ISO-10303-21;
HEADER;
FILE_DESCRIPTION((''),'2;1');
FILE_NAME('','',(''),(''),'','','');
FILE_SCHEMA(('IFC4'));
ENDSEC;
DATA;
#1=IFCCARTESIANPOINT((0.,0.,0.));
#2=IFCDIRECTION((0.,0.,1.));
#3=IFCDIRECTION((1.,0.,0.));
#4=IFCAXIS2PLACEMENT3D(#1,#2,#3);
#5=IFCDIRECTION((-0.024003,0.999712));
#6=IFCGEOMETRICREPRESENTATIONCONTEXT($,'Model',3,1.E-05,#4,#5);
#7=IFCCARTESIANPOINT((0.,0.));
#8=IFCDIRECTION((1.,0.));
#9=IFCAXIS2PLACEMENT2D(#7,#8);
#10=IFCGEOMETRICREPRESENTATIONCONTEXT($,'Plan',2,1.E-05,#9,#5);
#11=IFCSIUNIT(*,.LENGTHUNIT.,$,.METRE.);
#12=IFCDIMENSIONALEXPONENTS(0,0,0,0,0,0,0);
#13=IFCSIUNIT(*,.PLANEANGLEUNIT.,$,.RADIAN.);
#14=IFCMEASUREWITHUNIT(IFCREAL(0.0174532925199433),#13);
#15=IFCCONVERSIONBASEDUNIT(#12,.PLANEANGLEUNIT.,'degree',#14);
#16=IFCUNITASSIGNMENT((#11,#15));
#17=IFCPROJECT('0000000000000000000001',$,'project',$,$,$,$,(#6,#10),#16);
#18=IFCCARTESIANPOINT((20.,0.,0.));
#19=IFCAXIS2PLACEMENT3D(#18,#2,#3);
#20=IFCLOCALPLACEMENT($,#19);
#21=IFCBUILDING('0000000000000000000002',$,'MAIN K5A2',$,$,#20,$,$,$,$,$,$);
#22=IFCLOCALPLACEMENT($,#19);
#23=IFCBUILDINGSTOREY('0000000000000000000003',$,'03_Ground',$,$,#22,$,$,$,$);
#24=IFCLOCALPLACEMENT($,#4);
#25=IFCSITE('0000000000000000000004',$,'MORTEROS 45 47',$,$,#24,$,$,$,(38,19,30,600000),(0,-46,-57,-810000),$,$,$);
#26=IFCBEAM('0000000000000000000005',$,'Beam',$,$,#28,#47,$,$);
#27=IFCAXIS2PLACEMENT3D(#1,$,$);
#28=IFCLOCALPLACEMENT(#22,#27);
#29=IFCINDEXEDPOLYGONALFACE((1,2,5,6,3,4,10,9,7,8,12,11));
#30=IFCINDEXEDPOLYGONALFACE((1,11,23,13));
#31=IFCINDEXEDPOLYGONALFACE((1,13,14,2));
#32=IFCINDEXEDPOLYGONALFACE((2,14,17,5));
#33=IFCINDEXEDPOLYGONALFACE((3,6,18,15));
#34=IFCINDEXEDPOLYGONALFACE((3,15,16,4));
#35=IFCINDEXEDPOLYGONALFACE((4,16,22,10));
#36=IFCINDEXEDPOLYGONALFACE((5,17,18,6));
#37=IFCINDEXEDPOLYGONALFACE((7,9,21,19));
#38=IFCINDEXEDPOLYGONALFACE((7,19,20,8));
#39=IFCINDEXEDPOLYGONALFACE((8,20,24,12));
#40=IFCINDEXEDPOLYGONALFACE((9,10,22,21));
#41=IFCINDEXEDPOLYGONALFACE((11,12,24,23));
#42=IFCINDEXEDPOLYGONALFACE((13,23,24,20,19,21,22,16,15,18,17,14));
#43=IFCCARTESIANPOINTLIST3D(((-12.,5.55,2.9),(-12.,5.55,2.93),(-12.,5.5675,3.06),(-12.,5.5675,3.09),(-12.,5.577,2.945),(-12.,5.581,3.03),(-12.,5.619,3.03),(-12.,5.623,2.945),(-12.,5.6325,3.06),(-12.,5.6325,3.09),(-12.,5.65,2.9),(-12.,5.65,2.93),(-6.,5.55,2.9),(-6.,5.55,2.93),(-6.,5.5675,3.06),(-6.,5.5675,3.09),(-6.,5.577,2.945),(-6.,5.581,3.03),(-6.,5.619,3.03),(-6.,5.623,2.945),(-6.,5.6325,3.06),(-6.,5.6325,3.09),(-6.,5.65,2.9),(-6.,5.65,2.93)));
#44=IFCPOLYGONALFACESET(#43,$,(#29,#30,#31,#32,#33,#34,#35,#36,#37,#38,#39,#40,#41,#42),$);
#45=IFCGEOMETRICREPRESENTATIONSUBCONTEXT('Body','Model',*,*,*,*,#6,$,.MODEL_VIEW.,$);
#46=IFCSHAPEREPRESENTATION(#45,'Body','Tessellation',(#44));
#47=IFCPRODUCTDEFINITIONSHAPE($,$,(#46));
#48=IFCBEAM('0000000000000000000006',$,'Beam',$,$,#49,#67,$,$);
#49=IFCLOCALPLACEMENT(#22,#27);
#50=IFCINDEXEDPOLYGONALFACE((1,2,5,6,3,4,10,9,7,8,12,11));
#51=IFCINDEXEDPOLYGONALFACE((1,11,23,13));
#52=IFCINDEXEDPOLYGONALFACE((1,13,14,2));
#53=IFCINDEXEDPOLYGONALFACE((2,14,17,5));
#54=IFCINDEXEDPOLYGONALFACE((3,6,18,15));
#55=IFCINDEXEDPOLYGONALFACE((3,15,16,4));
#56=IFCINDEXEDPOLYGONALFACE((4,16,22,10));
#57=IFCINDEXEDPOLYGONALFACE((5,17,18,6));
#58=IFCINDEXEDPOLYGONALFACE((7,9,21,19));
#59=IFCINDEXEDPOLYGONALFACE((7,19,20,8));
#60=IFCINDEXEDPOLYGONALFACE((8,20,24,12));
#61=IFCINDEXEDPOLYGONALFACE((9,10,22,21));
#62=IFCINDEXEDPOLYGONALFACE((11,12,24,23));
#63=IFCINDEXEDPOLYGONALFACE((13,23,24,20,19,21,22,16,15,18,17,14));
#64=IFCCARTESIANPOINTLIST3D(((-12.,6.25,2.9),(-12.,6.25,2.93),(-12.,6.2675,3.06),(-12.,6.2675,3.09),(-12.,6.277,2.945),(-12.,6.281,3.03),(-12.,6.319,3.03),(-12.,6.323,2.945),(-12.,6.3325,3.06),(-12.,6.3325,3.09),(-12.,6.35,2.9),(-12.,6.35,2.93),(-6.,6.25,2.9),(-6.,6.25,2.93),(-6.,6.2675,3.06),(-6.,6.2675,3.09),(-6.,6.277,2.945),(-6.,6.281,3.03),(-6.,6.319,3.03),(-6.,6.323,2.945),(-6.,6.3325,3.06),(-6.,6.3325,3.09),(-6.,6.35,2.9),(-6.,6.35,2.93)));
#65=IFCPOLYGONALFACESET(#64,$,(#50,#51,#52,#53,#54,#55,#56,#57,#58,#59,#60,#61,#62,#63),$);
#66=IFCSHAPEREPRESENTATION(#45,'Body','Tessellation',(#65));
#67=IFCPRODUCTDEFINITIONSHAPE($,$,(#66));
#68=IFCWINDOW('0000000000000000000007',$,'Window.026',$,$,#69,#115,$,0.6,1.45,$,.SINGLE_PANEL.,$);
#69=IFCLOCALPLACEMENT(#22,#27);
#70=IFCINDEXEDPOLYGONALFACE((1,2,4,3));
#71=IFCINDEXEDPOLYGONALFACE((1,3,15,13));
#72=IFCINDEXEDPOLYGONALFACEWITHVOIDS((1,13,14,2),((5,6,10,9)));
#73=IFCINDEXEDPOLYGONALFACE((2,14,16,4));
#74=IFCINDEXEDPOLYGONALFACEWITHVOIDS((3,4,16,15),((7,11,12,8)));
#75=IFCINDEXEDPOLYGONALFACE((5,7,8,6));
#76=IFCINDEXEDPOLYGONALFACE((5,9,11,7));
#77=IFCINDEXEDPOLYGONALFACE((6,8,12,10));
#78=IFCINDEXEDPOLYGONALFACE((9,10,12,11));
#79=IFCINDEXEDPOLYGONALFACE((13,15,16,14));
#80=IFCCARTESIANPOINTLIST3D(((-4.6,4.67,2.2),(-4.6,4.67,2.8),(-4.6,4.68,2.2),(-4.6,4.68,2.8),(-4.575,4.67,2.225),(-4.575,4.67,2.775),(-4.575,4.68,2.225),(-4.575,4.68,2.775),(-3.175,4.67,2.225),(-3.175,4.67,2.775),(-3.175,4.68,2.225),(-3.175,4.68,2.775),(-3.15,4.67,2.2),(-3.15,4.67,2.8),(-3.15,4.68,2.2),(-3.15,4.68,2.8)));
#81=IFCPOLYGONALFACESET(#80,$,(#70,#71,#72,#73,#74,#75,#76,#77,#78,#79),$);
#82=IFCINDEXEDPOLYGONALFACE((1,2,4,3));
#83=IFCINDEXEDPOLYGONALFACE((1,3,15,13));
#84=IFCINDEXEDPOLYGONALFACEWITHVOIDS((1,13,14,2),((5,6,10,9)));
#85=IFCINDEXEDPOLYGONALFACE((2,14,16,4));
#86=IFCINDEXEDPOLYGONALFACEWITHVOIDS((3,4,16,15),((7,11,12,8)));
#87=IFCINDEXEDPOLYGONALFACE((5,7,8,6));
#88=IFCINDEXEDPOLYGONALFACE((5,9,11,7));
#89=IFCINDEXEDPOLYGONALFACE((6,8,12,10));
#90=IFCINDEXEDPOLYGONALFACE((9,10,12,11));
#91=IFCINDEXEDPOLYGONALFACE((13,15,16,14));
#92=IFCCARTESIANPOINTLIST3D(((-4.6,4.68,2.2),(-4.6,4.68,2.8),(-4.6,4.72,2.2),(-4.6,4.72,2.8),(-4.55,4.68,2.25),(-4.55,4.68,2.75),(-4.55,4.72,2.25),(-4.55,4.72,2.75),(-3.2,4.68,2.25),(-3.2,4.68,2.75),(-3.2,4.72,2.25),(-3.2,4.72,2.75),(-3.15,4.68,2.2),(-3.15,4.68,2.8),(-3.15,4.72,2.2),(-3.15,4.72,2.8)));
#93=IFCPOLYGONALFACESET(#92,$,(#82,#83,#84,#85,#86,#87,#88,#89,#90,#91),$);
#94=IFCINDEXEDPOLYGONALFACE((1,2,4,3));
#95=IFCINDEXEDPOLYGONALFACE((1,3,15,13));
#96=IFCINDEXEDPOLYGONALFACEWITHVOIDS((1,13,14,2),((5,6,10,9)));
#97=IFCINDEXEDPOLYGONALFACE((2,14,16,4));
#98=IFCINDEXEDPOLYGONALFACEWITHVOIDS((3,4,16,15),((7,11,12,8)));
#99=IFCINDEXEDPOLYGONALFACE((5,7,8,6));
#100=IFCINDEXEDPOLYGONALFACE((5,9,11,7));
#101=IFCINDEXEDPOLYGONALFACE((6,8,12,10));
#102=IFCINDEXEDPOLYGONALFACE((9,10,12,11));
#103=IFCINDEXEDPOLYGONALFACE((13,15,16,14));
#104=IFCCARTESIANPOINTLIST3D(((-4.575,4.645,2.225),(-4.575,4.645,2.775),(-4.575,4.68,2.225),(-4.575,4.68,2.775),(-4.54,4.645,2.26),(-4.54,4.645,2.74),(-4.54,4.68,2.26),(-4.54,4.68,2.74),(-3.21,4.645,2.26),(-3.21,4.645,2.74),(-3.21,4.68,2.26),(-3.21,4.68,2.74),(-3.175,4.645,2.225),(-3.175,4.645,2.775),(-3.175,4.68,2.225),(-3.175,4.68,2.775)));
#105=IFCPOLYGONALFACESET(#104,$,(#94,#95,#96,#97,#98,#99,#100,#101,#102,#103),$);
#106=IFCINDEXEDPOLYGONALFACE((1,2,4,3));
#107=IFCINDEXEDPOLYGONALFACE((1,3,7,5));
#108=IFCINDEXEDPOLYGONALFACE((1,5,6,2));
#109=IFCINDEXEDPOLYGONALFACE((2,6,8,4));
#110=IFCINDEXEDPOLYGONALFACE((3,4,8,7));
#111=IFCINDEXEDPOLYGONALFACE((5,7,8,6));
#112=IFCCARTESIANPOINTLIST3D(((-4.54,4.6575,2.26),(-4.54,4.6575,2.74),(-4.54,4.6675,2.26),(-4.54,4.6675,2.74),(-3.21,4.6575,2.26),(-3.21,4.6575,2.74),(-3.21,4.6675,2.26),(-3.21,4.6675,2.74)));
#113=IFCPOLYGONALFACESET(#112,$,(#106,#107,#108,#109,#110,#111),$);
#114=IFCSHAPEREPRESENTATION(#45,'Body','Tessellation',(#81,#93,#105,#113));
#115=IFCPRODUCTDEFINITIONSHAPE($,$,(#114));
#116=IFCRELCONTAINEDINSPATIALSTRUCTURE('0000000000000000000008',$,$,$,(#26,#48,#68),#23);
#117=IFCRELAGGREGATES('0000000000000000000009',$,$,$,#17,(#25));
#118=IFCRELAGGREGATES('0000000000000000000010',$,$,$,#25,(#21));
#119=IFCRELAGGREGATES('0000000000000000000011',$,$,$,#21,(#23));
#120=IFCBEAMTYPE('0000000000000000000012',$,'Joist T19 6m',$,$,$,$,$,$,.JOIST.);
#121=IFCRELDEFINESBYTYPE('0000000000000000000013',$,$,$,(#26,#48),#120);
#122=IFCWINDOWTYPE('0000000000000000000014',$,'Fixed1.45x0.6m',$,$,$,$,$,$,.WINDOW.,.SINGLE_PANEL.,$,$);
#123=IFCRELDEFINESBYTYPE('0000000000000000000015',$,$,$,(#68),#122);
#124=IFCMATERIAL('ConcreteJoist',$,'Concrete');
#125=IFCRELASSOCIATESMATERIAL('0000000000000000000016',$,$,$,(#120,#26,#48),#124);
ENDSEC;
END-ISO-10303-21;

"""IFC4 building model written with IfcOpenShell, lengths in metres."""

from ifc_helpers import new_model, entity, si_unit, converted_unit, direction, frame, origin_with_axes, origin_2d_with_axis, place, context, subcontext, project, spatial, line, indexed_curve, outline, extrude, shape, source, transform, mapped, material, material_profile, profile_set, profile_usage, type_object, element, save


model = new_model("IFC4")

# Units and contexts
model_context = context("Model", 3, precision=1e-05, world=origin_with_axes(), true_north=direction((-0.024003, 0.999712)))
plan_context = context("Plan", 2, precision=1e-05, world=origin_2d_with_axis(), true_north=direction((-0.024003, 0.999712)))
body_context_1 = subcontext(model_context, "Body", "Model", "MODEL_VIEW")
body_context_2 = subcontext(plan_context, "Body", "Plan", "PLAN_VIEW")
ifc_project = project(units=[si_unit("LENGTHUNIT", "METRE"), converted_unit("PLANEANGLEUNIT", "degree", entity("IfcReal", 0.0174532925199433), si_unit("PLANEANGLEUNIT", "RADIAN"), dimensions=[0, 0, 0, 0, 0, 0, 0])], contexts=[model_context, plan_context])

# Site, building, storey
site_placement = place(None, origin_with_axes())
site = spatial("IfcSite", under=ifc_project, at=site_placement, Name="MORTEROS 45 47", RefLatitude=(38, 19, 30, 600000), RefLongitude=(0, -46, -57, -810000))
building_placement = place(None, frame((20.0, 0.0, 0.0), z_axis=(0.0, 0.0, 1.0), x_axis=(1.0, 0.0, 0.0)))
building = spatial("IfcBuilding", under=site, at=building_placement, Name="MAIN K5A2")
storey_placement = place(None, frame((20.0, 0.0, 0.0), z_axis=(0.0, 0.0, 1.0), x_axis=(1.0, 0.0, 0.0)))
storey = spatial("IfcBuildingStorey", under=building, at=storey_placement, Name="03_Ground")

# Beams
ifc_material = material(Name="ConcreteJoist", Category="Concrete")
ifc_material_profile = material_profile(ifc_material, outline(indexed_curve([(0.019, 0.13), (0.023, 0.045), (0.05, 0.03), (0.05, 0.0), (-0.05, 0.0), (-0.05, 0.03), (-0.023, 0.045), (-0.019, 0.13), (-0.0325, 0.16), (-0.0325, 0.19), (0.0325, 0.19), (0.0325, 0.16), (0.019, 0.13)])))
ifc_profile_set = profile_set([ifc_material_profile], Name="JoistmaterialProfile")
beam_type = type_object("IfcBeamType", Name="Joist T19 6m", PredefinedType="JOIST", material=ifc_profile_set)
ifc_profile_usage_1 = profile_usage(ifc_profile_set)
beam_1_placement = place(None, frame((8.0, 5.6, 2.9), z_axis=(1.0, 0.0, 0.0), x_axis=(0.0, 1.0, 0.0)))
element("IfcBeam", 1, at=beam_1_placement, inside=storey, type_object=beam_type, material=ifc_profile_usage_1, Name="Beam", context=body_context_1, shape_type="SweptSolid", body=[
    extrude(outline(indexed_curve([(0.019, 0.13), (0.023, 0.045), (0.05, 0.03), (0.05, 0.0), (-0.05, 0.0), (-0.05, 0.03), (-0.023, 0.045), (-0.019, 0.13), (-0.0325, 0.16), (-0.0325, 0.19), (0.0325, 0.19), (0.0325, 0.16), (0.019, 0.13)])), origin_with_axes(), (0.0, 0.0, 1.0), 6.0),
])
ifc_profile_usage_2 = profile_usage(ifc_profile_set)
beam_2_placement = place(None, frame((8.0, 6.3, 2.9), z_axis=(1.0, 0.0, 0.0), x_axis=(0.0, 1.0, 0.0)))
element("IfcBeam", 2, at=beam_2_placement, inside=storey, type_object=beam_type, material=ifc_profile_usage_2, Name="Beam", context=body_context_1, shape_type="SweptSolid", body=[
    extrude(outline(indexed_curve([(0.019, 0.13), (0.023, 0.045), (0.05, 0.03), (0.05, 0.0), (-0.05, 0.0), (-0.05, 0.03), (-0.023, 0.045), (-0.019, 0.13), (-0.0325, 0.16), (-0.0325, 0.19), (0.0325, 0.19), (0.0325, 0.16), (0.019, 0.13)])), origin_with_axes(), (0.0, 0.0, 1.0), 6.0),
])

# Window
window_type_1 = type_object("IfcWindowType", Name="Fixed1.45x0.6m", PartitioningType="SINGLE_PANEL", PredefinedType="WINDOW")
shared_shape_1 = source(origin_with_axes(), body_context_1, "Body", "SolidModel", [
    extrude(outline(indexed_curve([(0.0, 0.0), (1.45, 0.0), (1.45, 0.6), (0.0, 0.6)], segments=[line(1, 2, 3, 4, 1)]), holes=[indexed_curve([(0.025, 0.025), (1.425, 0.025), (1.425, 0.575), (0.025, 0.575)], segments=[line(1, 2, 3, 4, 1)])]), frame((0.0, 0.09, 0.0), z_axis=(0.0, -1.0, 0.0), x_axis=(1.0, 0.0, 0.0)), (0.0, 0.0, -1.0), 0.01),
    extrude(outline(indexed_curve([(0.0, 0.0), (1.45, 0.0), (1.45, 0.6), (0.0, 0.6)], segments=[line(1, 2, 3, 4, 1)]), holes=[indexed_curve([(0.05, 0.05), (1.4, 0.05), (1.4, 0.55), (0.05, 0.55)], segments=[line(1, 2, 3, 4, 1)])]), frame((0.0, 0.05, 0.0), z_axis=(0.0, -1.0, 0.0), x_axis=(1.0, 0.0, 0.0)), (0.0, 0.0, -1.0), 0.04),
    extrude(outline(indexed_curve([(0.0, 0.0), (1.4, 0.0), (1.4, 0.55), (0.0, 0.55)], segments=[line(1, 2, 3, 4, 1)]), holes=[indexed_curve([(0.035, 0.035), (1.365, 0.035), (1.365, 0.515), (0.035, 0.515)], segments=[line(1, 2, 3, 4, 1)])]), frame((0.025, 0.09, 0.025), z_axis=(0.0, -1.0, 0.0), x_axis=(1.0, 0.0, 0.0)), (0.0, 0.0, -1.0), 0.035),
    extrude(outline(indexed_curve([(0.035, 0.035), (1.365, 0.035), (1.365, 0.515), (0.035, 0.515)], segments=[line(1, 2, 3, 4, 1)])), frame((0.025, 0.1025, 0.025), z_axis=(0.0, -1.0, 0.0), x_axis=(1.0, 0.0, 0.0)), (0.0, 0.0, -1.0), 0.01),
])
shared_shape_2 = source(origin_with_axes(), body_context_2, "Body", "Curve2D", [
    entity("IfcIndexedPolyCurve", entity("IfcCartesianPointList2D", [[0.05, 0.05], [1.4, 0.05]])),
    entity("IfcIndexedPolyCurve", entity("IfcCartesianPointList2D", [[0.0, 0.1], [0.025, 0.1], [0.025, 0.09], [0.05, 0.09], [0.05, 0.05], [0.0, 0.05]]), [entity("IfcLineIndex", [1, 2, 3, 4, 5, 6, 1])]),
    entity("IfcIndexedPolyCurve", entity("IfcCartesianPointList2D", [[1.45, 0.1], [1.425, 0.1], [1.425, 0.09], [1.4, 0.09], [1.4, 0.05], [1.45, 0.05]]), [entity("IfcLineIndex", [1, 2, 3, 4, 5, 6, 1])]),
    entity("IfcIndexedPolyCurve", entity("IfcCartesianPointList2D", [[0.025, 0.09], [0.06, 0.09], [0.06, 0.125], [0.025, 0.125]]), [entity("IfcLineIndex", [1, 2, 3, 4, 1])]),
    entity("IfcIndexedPolyCurve", entity("IfcCartesianPointList2D", [[1.425, 0.09], [1.39, 0.09], [1.39, 0.125], [1.425, 0.125]]), [entity("IfcLineIndex", [1, 2, 3, 4, 1])]),
    entity("IfcIndexedPolyCurve", entity("IfcCartesianPointList2D", [[0.06, 0.09], [1.39, 0.09]])),
    entity("IfcIndexedPolyCurve", entity("IfcCartesianPointList2D", [[0.06, 0.125], [1.39, 0.125]])),
    entity("IfcIndexedPolyCurve", entity("IfcCartesianPointList2D", [[0.06, 0.1075], [1.39, 0.1075]])),
])
window_1_placement = place(None, frame((16.85, 4.77, 2.2), z_axis=(0.0, 0.0, 1.0), x_axis=(-1.0, 0.0, 0.0)))
element("IfcWindow", 3, at=window_1_placement, inside=storey, type_object=window_type_1, Name="Window.026", OverallHeight=0.6, OverallWidth=1.45, PartitioningType="SINGLE_PANEL", shapes=[
    shape(body_context_1, "Body", "MappedRepresentation", [mapped(shared_shape_1, transform((0.0, 0.0, 0.0), x_axis=(1.0, 0.0, 0.0), y_axis=(0.0, 1.0, 0.0), z_axis=(0.0, 0.0, 1.0), scale=1.0))]),
    shape(body_context_2, "Body", "MappedRepresentation", [mapped(shared_shape_2, transform((0.0, 0.0, 0.0), x_axis=(1.0, 0.0, 0.0), y_axis=(0.0, 1.0, 0.0), z_axis=(0.0, 0.0, 1.0), scale=1.0))]),
])

save(model, "model.ifc")
